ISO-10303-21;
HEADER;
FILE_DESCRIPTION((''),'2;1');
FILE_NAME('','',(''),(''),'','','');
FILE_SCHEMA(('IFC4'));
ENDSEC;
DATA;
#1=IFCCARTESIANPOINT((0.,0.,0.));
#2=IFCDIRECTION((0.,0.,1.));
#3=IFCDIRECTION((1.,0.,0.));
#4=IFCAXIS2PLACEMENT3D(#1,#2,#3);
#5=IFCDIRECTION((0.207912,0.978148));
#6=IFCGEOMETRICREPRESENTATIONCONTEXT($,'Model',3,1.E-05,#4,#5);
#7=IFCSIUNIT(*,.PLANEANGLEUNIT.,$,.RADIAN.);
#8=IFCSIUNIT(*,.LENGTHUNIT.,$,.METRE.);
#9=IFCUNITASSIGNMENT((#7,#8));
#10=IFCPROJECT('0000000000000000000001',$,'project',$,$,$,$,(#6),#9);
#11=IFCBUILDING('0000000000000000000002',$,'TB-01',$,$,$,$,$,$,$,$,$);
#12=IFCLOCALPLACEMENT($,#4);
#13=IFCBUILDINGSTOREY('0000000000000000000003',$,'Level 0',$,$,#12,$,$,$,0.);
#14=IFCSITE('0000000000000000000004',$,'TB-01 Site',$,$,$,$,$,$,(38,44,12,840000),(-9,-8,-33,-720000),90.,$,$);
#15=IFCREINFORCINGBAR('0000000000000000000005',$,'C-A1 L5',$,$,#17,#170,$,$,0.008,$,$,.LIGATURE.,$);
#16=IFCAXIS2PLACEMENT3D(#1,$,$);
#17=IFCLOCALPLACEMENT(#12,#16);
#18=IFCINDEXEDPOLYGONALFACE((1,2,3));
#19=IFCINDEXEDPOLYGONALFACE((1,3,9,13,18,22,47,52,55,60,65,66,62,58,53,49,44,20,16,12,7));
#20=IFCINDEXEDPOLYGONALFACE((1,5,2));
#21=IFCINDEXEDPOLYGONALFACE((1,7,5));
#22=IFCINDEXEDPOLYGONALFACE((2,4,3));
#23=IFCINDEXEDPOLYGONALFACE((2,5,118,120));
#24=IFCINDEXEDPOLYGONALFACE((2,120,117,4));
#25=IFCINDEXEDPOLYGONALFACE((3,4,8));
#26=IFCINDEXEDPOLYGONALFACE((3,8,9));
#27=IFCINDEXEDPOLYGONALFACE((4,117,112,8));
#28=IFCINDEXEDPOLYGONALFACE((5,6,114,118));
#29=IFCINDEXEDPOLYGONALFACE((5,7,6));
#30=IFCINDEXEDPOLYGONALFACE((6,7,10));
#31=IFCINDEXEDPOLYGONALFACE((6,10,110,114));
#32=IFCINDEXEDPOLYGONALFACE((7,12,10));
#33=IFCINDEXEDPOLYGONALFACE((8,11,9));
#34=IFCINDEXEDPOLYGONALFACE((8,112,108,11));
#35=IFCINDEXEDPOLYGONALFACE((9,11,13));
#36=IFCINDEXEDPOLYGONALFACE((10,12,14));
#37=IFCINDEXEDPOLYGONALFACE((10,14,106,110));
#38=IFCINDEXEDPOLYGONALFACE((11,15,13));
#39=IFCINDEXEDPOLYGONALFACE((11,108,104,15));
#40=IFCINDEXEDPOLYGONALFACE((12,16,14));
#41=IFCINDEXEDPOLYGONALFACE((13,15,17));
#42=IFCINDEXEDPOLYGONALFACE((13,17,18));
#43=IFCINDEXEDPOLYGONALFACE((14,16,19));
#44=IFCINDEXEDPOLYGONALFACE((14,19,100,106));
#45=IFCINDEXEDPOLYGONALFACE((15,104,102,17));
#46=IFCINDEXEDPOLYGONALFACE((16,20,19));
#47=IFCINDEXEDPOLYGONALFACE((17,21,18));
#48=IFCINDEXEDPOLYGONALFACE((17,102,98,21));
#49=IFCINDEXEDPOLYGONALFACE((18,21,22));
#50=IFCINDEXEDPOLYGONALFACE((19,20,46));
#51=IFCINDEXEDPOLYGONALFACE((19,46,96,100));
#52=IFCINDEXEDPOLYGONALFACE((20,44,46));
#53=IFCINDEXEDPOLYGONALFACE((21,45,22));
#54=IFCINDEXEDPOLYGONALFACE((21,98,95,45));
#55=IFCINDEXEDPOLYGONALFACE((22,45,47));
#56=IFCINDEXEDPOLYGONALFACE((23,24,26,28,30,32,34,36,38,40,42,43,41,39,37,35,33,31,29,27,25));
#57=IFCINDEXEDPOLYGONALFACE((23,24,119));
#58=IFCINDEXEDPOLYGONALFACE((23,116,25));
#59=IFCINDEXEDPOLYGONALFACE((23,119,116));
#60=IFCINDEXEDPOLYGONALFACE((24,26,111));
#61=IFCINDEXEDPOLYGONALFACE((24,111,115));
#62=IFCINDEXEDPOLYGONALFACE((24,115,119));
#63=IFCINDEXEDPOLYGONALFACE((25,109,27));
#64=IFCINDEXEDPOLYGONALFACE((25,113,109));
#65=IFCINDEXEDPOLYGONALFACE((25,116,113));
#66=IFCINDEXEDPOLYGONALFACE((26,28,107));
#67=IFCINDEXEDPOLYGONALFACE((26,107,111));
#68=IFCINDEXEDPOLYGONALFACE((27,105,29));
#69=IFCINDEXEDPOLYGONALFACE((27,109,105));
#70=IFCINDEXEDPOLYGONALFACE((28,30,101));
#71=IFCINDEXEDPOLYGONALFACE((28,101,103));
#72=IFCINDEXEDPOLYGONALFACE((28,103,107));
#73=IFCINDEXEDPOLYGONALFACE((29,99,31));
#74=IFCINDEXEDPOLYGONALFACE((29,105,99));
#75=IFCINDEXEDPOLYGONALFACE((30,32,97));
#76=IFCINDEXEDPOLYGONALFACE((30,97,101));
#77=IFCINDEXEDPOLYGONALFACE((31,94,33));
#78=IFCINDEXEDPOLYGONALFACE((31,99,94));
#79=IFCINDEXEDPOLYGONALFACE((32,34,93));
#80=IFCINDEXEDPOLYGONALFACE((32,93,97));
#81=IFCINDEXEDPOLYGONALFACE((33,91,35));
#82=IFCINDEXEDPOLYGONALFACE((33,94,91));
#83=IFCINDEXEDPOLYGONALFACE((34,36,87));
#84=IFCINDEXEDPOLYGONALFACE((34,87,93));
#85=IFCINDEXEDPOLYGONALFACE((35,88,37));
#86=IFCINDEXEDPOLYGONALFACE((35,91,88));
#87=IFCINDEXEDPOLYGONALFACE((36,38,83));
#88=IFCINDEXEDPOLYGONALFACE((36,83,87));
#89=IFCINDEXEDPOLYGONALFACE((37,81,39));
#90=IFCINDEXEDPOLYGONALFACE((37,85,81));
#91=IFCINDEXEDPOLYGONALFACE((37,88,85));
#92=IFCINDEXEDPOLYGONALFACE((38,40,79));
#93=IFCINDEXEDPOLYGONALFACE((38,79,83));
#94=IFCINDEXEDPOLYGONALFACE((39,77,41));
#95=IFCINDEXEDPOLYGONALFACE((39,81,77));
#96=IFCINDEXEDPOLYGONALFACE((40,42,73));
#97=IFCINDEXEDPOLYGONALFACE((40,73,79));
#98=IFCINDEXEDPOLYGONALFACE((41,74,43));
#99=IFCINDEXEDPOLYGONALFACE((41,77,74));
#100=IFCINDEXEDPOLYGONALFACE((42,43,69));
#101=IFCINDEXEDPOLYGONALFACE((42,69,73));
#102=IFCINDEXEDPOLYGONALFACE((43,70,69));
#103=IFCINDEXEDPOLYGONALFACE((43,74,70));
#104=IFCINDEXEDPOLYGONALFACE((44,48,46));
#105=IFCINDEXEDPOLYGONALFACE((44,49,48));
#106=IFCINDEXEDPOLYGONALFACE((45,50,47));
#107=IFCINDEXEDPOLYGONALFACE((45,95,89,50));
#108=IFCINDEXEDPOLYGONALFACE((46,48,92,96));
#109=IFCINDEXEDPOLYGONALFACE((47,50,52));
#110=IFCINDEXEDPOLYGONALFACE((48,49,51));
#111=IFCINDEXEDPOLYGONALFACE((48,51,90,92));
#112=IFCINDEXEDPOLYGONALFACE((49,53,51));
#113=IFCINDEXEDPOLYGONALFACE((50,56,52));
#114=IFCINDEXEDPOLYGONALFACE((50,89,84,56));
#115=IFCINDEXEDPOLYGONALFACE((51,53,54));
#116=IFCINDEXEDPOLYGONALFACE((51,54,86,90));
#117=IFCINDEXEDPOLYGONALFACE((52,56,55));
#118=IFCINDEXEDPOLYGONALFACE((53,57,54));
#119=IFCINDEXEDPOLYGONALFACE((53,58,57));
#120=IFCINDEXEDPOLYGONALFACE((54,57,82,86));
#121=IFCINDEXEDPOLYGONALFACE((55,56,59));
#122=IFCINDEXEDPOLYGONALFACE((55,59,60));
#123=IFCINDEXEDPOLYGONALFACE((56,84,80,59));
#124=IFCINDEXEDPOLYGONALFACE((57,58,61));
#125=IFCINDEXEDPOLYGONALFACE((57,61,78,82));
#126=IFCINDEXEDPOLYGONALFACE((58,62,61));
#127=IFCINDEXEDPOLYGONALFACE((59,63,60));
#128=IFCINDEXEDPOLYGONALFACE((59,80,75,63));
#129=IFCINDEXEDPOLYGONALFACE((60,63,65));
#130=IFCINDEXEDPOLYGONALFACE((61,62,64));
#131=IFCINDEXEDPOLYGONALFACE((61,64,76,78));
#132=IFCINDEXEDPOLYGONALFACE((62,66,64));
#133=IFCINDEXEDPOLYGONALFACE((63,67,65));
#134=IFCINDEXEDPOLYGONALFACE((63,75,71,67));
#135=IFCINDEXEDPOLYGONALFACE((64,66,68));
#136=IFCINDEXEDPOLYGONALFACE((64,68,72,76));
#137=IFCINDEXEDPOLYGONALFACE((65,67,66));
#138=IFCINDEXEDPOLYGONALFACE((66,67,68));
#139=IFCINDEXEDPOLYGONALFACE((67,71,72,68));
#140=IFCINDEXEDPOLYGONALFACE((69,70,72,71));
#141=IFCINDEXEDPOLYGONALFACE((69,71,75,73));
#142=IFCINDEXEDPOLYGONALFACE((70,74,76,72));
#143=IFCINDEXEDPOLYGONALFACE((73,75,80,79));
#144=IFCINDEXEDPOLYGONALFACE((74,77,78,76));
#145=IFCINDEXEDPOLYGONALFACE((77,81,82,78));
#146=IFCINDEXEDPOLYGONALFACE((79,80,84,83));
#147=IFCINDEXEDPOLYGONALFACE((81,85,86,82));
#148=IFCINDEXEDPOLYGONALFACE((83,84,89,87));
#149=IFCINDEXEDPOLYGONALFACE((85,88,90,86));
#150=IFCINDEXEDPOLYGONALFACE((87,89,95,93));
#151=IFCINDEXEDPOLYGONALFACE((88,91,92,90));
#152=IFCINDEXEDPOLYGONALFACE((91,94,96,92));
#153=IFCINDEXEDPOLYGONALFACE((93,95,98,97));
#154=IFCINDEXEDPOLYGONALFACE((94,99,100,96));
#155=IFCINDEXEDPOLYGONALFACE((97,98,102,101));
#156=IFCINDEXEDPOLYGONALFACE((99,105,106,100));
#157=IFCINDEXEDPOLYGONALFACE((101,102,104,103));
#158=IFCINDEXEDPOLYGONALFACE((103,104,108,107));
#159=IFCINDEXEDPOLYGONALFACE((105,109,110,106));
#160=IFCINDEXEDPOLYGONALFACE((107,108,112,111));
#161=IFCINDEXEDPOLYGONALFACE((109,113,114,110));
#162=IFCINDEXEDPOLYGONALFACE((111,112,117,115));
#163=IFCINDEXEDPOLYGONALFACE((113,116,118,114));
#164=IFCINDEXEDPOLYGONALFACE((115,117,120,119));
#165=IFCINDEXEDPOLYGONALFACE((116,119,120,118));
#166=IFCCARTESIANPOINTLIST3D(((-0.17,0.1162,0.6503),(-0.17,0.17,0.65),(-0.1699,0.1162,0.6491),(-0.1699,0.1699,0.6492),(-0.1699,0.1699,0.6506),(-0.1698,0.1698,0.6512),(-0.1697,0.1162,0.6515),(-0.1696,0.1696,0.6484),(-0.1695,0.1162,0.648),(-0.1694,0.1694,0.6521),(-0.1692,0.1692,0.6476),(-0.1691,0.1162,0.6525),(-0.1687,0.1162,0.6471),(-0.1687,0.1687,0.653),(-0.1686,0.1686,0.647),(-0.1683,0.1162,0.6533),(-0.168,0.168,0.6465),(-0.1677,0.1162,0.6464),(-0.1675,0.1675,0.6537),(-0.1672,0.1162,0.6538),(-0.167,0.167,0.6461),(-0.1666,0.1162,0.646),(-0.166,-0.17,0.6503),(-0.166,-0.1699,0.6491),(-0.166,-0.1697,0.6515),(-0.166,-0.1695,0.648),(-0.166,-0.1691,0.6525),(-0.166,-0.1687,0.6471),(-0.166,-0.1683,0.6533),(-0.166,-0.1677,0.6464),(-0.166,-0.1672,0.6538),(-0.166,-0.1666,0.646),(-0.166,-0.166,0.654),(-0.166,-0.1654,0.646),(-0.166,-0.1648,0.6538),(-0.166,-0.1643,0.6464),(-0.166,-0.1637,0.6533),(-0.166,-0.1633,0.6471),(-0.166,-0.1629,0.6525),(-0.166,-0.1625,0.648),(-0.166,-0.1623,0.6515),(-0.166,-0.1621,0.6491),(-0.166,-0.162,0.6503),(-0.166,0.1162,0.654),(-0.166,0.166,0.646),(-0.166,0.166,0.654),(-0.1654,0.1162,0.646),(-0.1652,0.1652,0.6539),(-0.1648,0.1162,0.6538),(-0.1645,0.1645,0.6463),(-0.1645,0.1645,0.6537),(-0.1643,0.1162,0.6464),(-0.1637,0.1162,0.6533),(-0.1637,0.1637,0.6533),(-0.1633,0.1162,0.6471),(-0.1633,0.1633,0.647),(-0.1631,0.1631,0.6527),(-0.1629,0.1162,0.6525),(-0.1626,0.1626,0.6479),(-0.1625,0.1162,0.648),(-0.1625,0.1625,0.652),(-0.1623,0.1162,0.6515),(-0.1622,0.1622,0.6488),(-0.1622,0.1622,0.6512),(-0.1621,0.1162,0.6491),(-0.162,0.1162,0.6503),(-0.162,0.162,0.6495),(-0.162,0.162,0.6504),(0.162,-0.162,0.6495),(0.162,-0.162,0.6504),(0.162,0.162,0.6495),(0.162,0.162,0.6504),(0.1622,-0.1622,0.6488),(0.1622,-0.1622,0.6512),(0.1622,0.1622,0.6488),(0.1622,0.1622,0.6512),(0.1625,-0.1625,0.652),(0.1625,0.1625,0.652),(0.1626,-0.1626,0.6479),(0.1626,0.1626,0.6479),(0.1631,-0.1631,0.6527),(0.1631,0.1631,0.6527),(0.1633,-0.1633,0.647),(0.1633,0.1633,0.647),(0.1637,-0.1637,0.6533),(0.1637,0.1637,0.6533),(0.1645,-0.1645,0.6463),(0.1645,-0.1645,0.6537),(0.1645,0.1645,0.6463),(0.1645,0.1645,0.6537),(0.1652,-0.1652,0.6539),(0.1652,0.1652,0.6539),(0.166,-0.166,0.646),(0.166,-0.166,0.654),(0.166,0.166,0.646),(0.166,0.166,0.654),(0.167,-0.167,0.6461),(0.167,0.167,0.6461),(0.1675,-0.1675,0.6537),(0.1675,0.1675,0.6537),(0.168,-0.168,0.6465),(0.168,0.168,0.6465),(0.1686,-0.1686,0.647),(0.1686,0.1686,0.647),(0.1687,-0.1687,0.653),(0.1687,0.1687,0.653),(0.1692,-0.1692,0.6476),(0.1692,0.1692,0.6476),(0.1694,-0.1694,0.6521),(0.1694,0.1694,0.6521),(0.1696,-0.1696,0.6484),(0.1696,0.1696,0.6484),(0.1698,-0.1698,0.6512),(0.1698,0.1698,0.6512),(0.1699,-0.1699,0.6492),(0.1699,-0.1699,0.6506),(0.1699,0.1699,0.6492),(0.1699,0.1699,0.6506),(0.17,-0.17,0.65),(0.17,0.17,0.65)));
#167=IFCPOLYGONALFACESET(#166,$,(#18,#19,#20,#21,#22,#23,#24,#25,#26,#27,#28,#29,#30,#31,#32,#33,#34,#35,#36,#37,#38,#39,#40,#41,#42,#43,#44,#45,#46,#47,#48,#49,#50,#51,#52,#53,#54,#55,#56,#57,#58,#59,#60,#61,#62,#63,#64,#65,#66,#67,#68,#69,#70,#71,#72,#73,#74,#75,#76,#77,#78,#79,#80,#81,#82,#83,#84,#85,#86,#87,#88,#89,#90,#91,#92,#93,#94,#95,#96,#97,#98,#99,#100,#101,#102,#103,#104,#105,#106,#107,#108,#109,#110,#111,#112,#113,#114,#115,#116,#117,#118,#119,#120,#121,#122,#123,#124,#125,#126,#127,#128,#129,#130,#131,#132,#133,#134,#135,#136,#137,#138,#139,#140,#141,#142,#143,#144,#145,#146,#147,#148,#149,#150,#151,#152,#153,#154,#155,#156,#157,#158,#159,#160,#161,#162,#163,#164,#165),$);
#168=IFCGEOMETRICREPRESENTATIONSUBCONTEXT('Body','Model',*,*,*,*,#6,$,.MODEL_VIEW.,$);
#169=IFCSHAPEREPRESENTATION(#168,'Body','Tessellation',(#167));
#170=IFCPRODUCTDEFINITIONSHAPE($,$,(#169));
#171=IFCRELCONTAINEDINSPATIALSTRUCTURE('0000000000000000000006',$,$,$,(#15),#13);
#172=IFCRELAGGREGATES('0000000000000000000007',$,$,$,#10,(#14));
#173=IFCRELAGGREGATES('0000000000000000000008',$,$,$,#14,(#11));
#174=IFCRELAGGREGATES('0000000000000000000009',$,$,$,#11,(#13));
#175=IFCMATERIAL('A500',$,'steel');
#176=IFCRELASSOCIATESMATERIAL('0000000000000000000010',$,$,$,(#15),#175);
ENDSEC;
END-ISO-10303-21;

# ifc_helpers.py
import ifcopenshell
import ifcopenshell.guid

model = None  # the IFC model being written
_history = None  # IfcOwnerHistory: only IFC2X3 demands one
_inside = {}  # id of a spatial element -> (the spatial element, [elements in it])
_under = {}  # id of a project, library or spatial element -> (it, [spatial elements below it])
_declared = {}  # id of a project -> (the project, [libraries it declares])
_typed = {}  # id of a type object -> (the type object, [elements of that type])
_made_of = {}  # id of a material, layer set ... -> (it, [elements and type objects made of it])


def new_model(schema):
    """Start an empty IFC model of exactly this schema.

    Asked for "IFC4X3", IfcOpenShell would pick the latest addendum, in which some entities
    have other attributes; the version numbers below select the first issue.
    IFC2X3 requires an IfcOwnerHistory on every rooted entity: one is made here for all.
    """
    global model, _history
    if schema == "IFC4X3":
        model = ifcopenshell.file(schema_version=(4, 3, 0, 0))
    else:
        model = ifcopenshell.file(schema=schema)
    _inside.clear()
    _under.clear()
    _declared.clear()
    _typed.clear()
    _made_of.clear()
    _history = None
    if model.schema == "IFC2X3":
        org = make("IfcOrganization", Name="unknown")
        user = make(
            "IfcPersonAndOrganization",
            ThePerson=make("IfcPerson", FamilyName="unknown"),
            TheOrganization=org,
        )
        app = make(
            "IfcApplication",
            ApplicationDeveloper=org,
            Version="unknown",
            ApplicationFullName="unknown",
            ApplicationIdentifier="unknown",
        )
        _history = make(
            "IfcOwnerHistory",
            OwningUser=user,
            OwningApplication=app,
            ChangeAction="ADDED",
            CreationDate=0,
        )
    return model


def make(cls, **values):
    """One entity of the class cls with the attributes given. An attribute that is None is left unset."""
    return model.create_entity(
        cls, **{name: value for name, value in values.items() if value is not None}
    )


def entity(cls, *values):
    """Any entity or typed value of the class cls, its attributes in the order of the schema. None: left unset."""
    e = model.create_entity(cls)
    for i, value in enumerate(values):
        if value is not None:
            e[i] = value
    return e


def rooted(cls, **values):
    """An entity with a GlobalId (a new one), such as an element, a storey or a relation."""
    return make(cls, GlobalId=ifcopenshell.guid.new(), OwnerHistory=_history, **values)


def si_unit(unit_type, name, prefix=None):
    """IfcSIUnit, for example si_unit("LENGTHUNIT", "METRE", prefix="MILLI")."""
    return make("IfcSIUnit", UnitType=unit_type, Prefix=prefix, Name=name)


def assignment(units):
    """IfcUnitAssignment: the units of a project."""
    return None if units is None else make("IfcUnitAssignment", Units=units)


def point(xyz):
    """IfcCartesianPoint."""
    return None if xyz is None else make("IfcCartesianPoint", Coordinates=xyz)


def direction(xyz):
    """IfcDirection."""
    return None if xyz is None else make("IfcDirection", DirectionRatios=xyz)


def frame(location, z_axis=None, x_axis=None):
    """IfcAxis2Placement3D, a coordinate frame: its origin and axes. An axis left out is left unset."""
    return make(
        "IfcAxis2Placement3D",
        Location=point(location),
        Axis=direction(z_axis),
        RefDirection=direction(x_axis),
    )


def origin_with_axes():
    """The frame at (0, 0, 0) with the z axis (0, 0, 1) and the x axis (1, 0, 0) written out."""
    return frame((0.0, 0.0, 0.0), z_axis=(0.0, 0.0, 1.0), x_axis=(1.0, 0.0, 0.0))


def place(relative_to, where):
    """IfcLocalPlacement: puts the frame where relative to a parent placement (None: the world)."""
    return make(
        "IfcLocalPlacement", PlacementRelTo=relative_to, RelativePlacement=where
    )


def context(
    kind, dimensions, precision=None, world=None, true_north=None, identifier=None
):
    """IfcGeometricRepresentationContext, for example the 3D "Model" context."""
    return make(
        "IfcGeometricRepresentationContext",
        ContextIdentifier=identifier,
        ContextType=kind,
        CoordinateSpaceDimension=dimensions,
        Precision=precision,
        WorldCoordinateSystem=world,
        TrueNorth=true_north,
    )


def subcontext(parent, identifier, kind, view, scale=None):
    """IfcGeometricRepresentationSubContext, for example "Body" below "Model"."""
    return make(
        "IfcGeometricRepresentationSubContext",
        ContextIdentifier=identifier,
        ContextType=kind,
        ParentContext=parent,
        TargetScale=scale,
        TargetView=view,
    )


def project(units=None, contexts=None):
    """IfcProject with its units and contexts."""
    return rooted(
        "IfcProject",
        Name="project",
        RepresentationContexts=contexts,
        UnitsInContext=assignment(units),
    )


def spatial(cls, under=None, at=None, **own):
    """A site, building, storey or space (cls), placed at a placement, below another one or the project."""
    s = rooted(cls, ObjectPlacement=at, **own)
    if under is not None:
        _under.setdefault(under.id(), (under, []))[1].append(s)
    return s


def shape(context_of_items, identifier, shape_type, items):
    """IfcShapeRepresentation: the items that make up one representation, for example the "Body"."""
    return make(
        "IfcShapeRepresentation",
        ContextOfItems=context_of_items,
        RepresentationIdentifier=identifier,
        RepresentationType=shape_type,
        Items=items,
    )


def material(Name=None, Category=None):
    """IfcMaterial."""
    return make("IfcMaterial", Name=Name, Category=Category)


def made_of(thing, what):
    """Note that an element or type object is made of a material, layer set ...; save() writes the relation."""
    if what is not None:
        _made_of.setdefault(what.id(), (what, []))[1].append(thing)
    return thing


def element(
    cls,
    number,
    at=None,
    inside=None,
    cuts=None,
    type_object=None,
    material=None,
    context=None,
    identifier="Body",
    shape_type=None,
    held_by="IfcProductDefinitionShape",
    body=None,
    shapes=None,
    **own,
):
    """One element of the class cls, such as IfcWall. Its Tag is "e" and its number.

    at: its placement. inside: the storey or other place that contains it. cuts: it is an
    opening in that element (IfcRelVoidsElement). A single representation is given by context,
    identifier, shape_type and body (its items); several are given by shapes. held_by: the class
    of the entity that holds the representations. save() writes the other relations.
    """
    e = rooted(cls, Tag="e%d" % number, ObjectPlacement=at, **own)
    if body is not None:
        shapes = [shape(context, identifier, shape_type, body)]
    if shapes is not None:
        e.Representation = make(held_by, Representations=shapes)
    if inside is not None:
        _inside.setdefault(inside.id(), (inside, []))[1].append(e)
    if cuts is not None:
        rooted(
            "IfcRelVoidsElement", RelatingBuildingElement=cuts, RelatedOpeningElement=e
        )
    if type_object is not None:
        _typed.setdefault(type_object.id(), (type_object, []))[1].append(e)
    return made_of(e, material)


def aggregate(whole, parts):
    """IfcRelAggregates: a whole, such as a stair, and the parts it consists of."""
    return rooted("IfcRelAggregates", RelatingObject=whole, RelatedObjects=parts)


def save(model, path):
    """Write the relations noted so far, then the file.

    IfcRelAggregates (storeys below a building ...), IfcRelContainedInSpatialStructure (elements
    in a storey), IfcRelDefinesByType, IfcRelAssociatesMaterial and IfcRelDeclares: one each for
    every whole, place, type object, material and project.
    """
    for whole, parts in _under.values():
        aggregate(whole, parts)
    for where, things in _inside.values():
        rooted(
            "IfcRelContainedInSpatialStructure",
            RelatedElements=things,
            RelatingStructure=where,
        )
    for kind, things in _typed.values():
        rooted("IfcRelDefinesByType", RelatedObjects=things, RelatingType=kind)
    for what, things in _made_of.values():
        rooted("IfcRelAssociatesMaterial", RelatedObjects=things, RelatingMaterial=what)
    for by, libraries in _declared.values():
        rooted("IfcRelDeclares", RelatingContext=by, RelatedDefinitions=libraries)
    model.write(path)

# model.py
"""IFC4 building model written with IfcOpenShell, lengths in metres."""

from ifc_helpers import new_model, entity, si_unit, direction, origin_with_axes, place, context, subcontext, project, spatial, material, element, save


model = new_model("IFC4")

# Units and contexts
model_context = context("Model", 3, precision=1e-05, world=origin_with_axes(), true_north=direction((0.207912, 0.978148)))
body_context = subcontext(model_context, "Body", "Model", "MODEL_VIEW")
ifc_project = project(units=[si_unit("PLANEANGLEUNIT", "RADIAN"), si_unit("LENGTHUNIT", "METRE")], contexts=[model_context])

# Site, building, storey
site = spatial("IfcSite", under=ifc_project, Name="TB-01 Site", RefLatitude=(38, 44, 12, 840000), RefLongitude=(-9, -8, -33, -720000), RefElevation=90.0)
building = spatial("IfcBuilding", under=site, Name="TB-01")
storey_placement = place(None, origin_with_axes())
storey = spatial("IfcBuildingStorey", under=building, at=storey_placement, Name="Level 0", Elevation=0.0)

# Reinforcing bar
ifc_material_1 = material(Name="A500", Category="steel")
reinforcing_bar_1_placement = place(storey_placement, origin_with_axes())
element("IfcReinforcingBar", 1, at=reinforcing_bar_1_placement, inside=storey, material=ifc_material_1, Name="C-A1 L5", NominalDiameter=0.008, PredefinedType="LIGATURE", context=body_context, shape_type="AdvancedSweptSolid", body=[
    entity("IfcSweptDiskSolid", entity("IfcPolyline", [entity("IfcCartesianPoint", [-0.166, -0.166, 0.65]), entity("IfcCartesianPoint", [0.166, -0.166, 0.65]), entity("IfcCartesianPoint", [0.166, 0.166, 0.65]), entity("IfcCartesianPoint", [-0.166, 0.166, 0.65]), entity("IfcCartesianPoint", [-0.166, 0.1162, 0.65])]), 0.004),
])

save(model, "model.ifc")
